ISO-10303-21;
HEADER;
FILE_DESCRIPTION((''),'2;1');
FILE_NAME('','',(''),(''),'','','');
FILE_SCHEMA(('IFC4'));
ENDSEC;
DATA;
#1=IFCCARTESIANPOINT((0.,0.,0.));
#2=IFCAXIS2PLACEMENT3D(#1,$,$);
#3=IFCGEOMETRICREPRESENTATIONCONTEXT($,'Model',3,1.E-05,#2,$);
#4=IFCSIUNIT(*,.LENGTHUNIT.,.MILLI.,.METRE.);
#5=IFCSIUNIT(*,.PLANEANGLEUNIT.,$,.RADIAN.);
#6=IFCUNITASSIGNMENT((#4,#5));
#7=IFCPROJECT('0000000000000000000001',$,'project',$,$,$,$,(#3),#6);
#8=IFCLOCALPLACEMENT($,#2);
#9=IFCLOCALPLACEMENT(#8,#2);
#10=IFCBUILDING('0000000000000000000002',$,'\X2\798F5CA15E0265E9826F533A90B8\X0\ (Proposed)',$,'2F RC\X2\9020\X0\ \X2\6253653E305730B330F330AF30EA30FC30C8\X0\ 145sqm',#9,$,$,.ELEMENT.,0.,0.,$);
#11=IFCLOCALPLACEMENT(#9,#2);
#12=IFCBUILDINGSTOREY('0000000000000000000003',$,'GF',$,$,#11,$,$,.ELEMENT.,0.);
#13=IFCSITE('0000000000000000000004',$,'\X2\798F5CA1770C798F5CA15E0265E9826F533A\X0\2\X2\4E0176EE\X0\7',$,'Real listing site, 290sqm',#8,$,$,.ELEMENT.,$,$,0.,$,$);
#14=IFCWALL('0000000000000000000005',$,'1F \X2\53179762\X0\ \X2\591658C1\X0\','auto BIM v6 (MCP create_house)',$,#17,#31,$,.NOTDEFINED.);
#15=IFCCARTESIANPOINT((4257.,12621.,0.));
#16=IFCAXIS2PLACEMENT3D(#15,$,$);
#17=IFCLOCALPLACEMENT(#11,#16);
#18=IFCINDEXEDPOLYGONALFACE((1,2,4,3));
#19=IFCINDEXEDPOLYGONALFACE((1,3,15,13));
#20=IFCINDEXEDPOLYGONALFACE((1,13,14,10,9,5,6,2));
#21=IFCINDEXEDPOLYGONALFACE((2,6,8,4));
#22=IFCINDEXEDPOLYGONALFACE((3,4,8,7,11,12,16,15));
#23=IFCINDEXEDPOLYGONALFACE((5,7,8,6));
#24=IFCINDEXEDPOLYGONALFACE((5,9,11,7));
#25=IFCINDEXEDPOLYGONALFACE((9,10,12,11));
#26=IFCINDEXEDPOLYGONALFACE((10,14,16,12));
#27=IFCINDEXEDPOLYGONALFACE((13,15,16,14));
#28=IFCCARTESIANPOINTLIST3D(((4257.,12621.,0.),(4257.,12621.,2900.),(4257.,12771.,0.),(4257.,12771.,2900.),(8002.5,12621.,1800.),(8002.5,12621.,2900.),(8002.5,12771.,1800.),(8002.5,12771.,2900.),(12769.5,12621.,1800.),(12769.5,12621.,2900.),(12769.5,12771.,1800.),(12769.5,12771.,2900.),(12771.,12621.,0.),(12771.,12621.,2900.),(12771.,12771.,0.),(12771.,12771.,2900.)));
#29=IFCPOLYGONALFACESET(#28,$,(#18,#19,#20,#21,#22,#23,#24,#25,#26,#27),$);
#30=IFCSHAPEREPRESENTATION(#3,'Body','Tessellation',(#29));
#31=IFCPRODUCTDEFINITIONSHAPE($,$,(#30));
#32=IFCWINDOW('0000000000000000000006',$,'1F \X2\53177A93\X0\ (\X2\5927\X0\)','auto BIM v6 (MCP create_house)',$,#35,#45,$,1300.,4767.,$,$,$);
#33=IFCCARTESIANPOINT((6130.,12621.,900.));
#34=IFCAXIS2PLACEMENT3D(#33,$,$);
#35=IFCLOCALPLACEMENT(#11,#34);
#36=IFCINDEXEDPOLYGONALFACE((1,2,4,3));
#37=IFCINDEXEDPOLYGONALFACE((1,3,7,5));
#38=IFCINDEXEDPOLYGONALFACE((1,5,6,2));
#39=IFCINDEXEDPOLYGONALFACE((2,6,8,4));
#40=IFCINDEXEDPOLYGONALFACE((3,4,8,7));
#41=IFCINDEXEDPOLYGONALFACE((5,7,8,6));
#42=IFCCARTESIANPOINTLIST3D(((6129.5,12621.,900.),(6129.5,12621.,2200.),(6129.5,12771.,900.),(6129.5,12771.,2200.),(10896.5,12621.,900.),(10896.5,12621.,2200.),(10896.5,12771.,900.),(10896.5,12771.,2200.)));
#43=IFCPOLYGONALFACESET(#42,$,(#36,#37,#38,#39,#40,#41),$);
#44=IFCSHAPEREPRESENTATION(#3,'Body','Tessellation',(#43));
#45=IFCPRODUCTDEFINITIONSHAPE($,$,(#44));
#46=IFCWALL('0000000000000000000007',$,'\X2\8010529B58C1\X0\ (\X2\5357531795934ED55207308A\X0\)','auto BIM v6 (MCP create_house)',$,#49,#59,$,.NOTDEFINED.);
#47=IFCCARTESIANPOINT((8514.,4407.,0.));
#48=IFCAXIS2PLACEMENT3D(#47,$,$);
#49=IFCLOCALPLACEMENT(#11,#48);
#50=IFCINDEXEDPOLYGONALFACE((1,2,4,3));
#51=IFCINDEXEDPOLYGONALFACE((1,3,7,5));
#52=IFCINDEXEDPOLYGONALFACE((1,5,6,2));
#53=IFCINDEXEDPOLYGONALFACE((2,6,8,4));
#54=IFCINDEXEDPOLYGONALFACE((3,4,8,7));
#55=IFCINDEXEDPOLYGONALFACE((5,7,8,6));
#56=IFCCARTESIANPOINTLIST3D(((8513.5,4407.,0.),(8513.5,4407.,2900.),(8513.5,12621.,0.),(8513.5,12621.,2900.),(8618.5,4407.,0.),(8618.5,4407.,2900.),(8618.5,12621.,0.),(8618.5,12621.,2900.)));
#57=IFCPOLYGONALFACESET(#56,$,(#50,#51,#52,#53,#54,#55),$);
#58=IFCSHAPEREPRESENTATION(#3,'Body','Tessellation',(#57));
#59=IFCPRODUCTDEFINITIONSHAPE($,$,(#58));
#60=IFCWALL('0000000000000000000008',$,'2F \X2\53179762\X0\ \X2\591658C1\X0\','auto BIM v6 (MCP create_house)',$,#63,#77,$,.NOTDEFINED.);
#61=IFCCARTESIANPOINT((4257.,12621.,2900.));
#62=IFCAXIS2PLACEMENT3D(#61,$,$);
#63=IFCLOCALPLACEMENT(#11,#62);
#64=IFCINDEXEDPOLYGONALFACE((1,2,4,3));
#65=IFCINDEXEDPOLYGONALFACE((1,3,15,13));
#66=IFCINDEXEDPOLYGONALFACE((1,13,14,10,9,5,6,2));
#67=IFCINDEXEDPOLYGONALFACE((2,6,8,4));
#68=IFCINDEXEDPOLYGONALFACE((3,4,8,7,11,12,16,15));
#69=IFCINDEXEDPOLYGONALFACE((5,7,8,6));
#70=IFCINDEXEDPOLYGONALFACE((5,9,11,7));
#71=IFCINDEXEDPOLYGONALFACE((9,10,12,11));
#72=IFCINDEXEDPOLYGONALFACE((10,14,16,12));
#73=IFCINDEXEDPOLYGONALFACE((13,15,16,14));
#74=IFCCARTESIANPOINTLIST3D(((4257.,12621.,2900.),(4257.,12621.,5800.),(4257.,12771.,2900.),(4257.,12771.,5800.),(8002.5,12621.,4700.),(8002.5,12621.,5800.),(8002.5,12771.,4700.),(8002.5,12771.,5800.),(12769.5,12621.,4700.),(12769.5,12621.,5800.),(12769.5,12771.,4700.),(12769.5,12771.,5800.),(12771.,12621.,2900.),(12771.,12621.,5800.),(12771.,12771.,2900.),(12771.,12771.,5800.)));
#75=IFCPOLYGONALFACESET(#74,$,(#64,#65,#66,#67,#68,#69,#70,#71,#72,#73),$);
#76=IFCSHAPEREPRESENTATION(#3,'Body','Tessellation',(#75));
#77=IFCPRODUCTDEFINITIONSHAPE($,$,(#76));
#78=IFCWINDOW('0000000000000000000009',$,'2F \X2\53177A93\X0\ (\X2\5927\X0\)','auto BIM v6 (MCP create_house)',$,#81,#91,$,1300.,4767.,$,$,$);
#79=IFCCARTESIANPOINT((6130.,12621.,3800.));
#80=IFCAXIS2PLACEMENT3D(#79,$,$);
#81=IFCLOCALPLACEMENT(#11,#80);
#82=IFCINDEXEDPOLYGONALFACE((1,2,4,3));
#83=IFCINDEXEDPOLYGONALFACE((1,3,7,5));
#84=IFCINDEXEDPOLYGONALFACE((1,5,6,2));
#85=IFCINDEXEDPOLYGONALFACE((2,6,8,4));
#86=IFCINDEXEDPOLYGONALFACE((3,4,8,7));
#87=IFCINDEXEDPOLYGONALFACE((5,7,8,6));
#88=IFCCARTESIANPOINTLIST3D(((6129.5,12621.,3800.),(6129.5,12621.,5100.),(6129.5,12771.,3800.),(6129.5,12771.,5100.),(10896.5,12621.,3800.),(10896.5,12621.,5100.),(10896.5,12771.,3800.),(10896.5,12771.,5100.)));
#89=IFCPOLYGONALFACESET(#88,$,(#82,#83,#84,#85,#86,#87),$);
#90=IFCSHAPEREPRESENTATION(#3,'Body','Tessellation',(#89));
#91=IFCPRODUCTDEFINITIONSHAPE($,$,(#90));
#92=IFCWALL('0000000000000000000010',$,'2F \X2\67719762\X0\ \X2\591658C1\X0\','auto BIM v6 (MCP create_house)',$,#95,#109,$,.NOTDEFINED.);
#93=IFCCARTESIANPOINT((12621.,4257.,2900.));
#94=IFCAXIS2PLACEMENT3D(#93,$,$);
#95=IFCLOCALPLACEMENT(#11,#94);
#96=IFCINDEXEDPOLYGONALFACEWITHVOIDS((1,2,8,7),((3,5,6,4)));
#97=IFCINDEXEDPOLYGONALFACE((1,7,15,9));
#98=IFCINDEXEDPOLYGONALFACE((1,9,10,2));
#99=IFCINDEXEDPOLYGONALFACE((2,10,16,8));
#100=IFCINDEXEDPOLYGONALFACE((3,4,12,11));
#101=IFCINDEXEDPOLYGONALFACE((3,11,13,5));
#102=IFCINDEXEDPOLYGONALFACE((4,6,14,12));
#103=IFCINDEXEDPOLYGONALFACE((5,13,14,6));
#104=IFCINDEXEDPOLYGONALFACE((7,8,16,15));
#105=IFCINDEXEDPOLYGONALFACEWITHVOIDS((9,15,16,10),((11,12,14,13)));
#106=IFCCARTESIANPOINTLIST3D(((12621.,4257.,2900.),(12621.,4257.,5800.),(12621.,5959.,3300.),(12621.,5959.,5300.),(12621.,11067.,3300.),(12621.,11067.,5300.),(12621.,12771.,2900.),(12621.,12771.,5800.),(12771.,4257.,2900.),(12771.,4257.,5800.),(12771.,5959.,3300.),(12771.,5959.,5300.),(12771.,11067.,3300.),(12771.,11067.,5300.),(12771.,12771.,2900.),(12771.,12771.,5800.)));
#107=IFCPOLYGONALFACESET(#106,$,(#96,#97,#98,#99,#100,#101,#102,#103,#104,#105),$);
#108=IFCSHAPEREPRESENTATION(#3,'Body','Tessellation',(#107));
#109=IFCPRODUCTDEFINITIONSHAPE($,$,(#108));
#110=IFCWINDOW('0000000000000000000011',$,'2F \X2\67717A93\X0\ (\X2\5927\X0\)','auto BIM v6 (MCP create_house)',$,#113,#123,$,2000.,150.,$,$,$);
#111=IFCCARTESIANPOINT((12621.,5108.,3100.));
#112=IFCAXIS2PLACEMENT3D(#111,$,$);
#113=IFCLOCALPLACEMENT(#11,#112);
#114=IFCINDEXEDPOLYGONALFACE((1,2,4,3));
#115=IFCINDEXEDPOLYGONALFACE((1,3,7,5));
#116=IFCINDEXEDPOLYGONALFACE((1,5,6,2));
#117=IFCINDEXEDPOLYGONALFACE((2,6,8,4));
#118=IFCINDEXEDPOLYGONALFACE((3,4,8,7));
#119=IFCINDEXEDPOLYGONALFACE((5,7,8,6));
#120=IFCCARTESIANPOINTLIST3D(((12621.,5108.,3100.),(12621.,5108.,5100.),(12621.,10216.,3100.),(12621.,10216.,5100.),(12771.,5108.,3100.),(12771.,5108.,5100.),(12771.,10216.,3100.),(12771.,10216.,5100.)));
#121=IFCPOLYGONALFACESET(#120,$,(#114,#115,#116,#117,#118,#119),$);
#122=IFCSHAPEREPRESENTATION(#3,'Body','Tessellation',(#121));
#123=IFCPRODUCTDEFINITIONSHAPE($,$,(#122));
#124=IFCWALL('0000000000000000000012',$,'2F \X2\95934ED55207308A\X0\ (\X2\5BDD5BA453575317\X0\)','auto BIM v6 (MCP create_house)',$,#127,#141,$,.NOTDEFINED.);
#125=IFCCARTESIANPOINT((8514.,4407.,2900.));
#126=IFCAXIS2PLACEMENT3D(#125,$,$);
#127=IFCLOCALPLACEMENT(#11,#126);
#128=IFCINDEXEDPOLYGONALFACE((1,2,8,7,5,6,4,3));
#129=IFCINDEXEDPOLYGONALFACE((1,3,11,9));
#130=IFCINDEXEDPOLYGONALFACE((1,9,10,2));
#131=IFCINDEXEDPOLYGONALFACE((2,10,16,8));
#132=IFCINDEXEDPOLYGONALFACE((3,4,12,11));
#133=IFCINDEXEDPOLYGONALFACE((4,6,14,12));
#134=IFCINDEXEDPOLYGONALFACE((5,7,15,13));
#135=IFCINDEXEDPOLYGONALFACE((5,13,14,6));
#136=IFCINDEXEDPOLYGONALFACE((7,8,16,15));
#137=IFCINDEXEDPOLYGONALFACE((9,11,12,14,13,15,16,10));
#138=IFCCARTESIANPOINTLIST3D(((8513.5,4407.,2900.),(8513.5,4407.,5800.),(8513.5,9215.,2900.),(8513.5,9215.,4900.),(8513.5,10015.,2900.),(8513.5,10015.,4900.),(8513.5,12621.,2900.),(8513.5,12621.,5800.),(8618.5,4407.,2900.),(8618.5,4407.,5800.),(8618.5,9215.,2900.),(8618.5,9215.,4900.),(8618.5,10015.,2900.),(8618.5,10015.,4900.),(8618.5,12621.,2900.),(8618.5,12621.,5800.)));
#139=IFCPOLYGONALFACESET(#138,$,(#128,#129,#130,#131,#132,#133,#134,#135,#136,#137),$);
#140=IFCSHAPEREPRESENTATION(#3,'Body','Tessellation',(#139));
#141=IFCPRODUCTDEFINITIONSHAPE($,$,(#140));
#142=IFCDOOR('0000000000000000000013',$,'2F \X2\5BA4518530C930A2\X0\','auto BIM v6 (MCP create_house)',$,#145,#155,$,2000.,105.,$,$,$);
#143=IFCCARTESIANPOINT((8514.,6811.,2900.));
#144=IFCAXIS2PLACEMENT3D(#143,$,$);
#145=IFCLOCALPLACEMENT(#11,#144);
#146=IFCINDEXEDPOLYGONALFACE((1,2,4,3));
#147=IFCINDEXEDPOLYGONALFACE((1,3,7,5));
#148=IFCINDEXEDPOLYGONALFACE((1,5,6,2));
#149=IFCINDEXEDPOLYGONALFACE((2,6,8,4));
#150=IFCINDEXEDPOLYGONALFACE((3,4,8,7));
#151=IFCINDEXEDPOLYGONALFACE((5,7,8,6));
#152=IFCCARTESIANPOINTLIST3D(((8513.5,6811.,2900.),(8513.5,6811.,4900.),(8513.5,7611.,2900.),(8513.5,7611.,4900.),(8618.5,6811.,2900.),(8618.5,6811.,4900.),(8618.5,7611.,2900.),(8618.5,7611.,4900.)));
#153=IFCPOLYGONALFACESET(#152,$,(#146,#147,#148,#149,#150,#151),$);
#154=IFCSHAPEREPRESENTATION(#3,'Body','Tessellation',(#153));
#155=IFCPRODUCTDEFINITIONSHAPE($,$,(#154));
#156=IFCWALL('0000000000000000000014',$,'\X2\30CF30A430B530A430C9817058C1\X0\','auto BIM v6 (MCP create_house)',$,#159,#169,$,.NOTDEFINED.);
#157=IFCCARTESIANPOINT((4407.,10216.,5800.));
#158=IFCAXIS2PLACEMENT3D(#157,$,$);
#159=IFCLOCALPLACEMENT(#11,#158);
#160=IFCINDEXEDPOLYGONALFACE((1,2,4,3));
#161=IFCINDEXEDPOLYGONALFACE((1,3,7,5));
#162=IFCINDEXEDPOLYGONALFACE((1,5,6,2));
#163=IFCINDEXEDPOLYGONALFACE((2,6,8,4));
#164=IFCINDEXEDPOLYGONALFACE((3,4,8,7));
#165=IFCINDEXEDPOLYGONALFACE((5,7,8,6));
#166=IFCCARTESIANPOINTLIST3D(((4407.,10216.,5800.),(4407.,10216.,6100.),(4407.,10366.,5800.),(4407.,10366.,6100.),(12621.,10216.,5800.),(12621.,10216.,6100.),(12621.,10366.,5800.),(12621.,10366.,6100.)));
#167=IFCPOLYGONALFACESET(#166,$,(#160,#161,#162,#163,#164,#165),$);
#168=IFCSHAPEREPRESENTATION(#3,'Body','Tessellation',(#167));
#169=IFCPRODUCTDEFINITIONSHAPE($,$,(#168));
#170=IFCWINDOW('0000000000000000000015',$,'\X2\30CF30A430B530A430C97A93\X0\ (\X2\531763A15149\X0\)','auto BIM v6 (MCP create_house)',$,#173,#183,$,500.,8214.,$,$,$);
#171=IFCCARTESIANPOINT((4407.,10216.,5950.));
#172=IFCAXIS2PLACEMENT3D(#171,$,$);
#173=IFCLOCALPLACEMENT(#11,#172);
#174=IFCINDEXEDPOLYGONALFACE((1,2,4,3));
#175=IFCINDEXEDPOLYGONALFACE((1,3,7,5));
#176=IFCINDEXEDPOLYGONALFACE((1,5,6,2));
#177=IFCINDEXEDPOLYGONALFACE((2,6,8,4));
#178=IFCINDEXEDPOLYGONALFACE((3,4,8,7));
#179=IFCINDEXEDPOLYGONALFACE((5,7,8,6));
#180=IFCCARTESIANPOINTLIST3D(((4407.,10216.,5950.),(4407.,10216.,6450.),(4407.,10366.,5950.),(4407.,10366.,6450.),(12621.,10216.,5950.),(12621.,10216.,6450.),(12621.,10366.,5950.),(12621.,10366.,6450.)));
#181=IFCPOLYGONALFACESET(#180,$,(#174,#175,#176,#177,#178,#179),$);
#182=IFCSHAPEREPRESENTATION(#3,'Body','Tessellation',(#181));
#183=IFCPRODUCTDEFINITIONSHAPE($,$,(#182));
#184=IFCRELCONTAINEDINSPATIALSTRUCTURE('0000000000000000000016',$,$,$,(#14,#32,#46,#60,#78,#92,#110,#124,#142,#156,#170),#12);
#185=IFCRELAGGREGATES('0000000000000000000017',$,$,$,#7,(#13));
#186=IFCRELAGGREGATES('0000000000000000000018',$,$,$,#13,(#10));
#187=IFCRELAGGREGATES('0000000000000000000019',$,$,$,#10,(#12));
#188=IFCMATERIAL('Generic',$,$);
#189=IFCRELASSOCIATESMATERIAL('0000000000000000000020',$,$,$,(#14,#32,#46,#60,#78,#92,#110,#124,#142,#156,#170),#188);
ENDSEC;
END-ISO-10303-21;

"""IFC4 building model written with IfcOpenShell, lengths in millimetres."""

from ifc_helpers import new_model, si_unit, frame, frame_2d, origin, place, context, project, spatial, rectangle, extrude, material, element, fill, save


model = new_model("IFC4")

# Units and contexts
model_context = context("Model", 3, precision=1e-05, world=origin())
ifc_project = project(units=[si_unit("LENGTHUNIT", "METRE", prefix="MILLI"), si_unit("PLANEANGLEUNIT", "RADIAN")], contexts=[model_context])

# Site, building, storey
site_placement = place(None, origin())
site = spatial("IfcSite", under=ifc_project, at=site_placement, Name="福岡県福岡市早良区2丁目7", ObjectType="Real listing site, 290sqm", CompositionType="ELEMENT", RefElevation=0.0)
building_placement = place(site_placement, origin())
building = spatial("IfcBuilding", under=site, at=building_placement, Name="福岡市早良区邸 (Proposed)", ObjectType="2F RC造 打放しコンクリート 145sqm", CompositionType="ELEMENT", ElevationOfRefHeight=0.0, ElevationOfTerrain=0.0)
storey_placement = place(building_placement, origin())
storey = spatial("IfcBuildingStorey", under=building, at=storey_placement, Name="GF", CompositionType="ELEMENT", Elevation=0.0)

# Wall, opening, window
ifc_material = material(Name="Generic")
wall_1_placement = place(storey_placement, frame((4257.0, 12621.0, 0.0)))
wall_1 = element("IfcWall", 1, at=wall_1_placement, inside=storey, material=ifc_material, Name="1F 北面 外壁", Description="auto BIM v6 (MCP create_house)", PredefinedType="NOTDEFINED", context=model_context, shape_type="SweptSolid", body=[
    extrude(rectangle(XDim=8514.0, YDim=150.0, at=frame_2d((4257.0, 75.0))), frame((4257.0, 12621.0, 0.0)), (0.0, 0.0, 1.0), 2900.0),
])
opening_1_placement = place(storey_placement, frame((6130.0, 12621.0, 900.0)))
opening_1 = element("IfcOpeningElement", 2, at=opening_1_placement, cuts=wall_1, PredefinedType="NOTDEFINED", context=model_context, shape_type="SweptSolid", body=[
    extrude(rectangle(XDim=4767.0, YDim=150.0, at=frame_2d((2383.0, 75.0))), frame((6130.0, 12621.0, 900.0)), (0.0, 0.0, 1.0), 1300.0),
])
window_1_placement = place(storey_placement, frame((6130.0, 12621.0, 900.0)))
window_1 = element("IfcWindow", 3, at=window_1_placement, inside=storey, material=ifc_material, Name="1F 北窓 (大)", Description="auto BIM v6 (MCP create_house)", OverallHeight=1300.0, OverallWidth=4767.0, context=model_context, shape_type="SweptSolid", body=[
    extrude(rectangle(XDim=4767.0, YDim=150.0, at=frame_2d((2383.0, 75.0))), frame((6130.0, 12621.0, 900.0)), (0.0, 0.0, 1.0), 1300.0),
])
fill(opening_1, window_1)

# Wall
wall_2_placement = place(storey_placement, frame((8514.0, 4407.0, 0.0)))
element("IfcWall", 4, at=wall_2_placement, inside=storey, material=ifc_material, Name="耐力壁 (南北間仕切り)", Description="auto BIM v6 (MCP create_house)", PredefinedType="NOTDEFINED", context=model_context, shape_type="SweptSolid", body=[
    extrude(rectangle(XDim=105.0, YDim=8214.0, at=frame_2d((52.0, 4107.0))), frame((8514.0, 4407.0, 0.0)), (0.0, 0.0, 1.0), 2900.0),
])

# Walls, openings, windows
wall_3_placement = place(storey_placement, frame((4257.0, 12621.0, 2900.0)))
wall_3 = element("IfcWall", 5, at=wall_3_placement, inside=storey, material=ifc_material, Name="2F 北面 外壁", Description="auto BIM v6 (MCP create_house)", PredefinedType="NOTDEFINED", context=model_context, shape_type="SweptSolid", body=[
    extrude(rectangle(XDim=8514.0, YDim=150.0, at=frame_2d((4257.0, 75.0))), frame((4257.0, 12621.0, 2900.0)), (0.0, 0.0, 1.0), 2900.0),
])
opening_2_placement = place(storey_placement, frame((6130.0, 12621.0, 3800.0)))
opening_2 = element("IfcOpeningElement", 6, at=opening_2_placement, cuts=wall_3, PredefinedType="NOTDEFINED", context=model_context, shape_type="SweptSolid", body=[
    extrude(rectangle(XDim=4767.0, YDim=150.0, at=frame_2d((2383.0, 75.0))), frame((6130.0, 12621.0, 3800.0)), (0.0, 0.0, 1.0), 1300.0),
])
window_2_placement = place(storey_placement, frame((6130.0, 12621.0, 3800.0)))
window_2 = element("IfcWindow", 7, at=window_2_placement, inside=storey, material=ifc_material, Name="2F 北窓 (大)", Description="auto BIM v6 (MCP create_house)", OverallHeight=1300.0, OverallWidth=4767.0, context=model_context, shape_type="SweptSolid", body=[
    extrude(rectangle(XDim=4767.0, YDim=150.0, at=frame_2d((2383.0, 75.0))), frame((6130.0, 12621.0, 3800.0)), (0.0, 0.0, 1.0), 1300.0),
])
fill(opening_2, window_2)
wall_4_placement = place(storey_placement, frame((12621.0, 4257.0, 2900.0)))
wall_4 = element("IfcWall", 8, at=wall_4_placement, inside=storey, material=ifc_material, Name="2F 東面 外壁", Description="auto BIM v6 (MCP create_house)", PredefinedType="NOTDEFINED", context=model_context, shape_type="SweptSolid", body=[
    extrude(rectangle(XDim=150.0, YDim=8514.0, at=frame_2d((75.0, 4257.0))), frame((12621.0, 4257.0, 2900.0)), (0.0, 0.0, 1.0), 2900.0),
])
opening_3_placement = place(storey_placement, frame((12621.0, 5108.0, 3100.0)))
opening_3 = element("IfcOpeningElement", 9, at=opening_3_placement, cuts=wall_4, PredefinedType="NOTDEFINED", context=model_context, shape_type="SweptSolid", body=[
    extrude(rectangle(XDim=150.0, YDim=5108.0, at=frame_2d((75.0, 2554.0))), frame((12621.0, 5108.0, 3100.0)), (0.0, 0.0, 1.0), 2000.0),
])
window_3_placement = place(storey_placement, frame((12621.0, 5108.0, 3100.0)))
window_3 = element("IfcWindow", 10, at=window_3_placement, inside=storey, material=ifc_material, Name="2F 東窓 (大)", Description="auto BIM v6 (MCP create_house)", OverallHeight=2000.0, OverallWidth=150.0, context=model_context, shape_type="SweptSolid", body=[
    extrude(rectangle(XDim=150.0, YDim=5108.0, at=frame_2d((75.0, 2554.0))), frame((12621.0, 5108.0, 3100.0)), (0.0, 0.0, 1.0), 2000.0),
])
fill(opening_3, window_3)

# Wall, opening, door
wall_5_placement = place(storey_placement, frame((8514.0, 4407.0, 2900.0)))
wall_5 = element("IfcWall", 11, at=wall_5_placement, inside=storey, material=ifc_material, Name="2F 間仕切り (寝室南北)", Description="auto BIM v6 (MCP create_house)", PredefinedType="NOTDEFINED", context=model_context, shape_type="SweptSolid", body=[
    extrude(rectangle(XDim=105.0, YDim=8214.0, at=frame_2d((52.0, 4107.0))), frame((8514.0, 4407.0, 2900.0)), (0.0, 0.0, 1.0), 2900.0),
])
opening_4_placement = place(storey_placement, frame((8514.0, 6811.0, 2900.0)))
opening_4 = element("IfcOpeningElement", 12, at=opening_4_placement, cuts=wall_5, PredefinedType="NOTDEFINED", context=model_context, shape_type="SweptSolid", body=[
    extrude(rectangle(XDim=105.0, YDim=800.0, at=frame_2d((52.0, 400.0))), frame((8514.0, 6811.0, 2900.0)), (0.0, 0.0, 1.0), 2000.0),
])
door_placement = place(storey_placement, frame((8514.0, 6811.0, 2900.0)))
door = element("IfcDoor", 13, at=door_placement, inside=storey, material=ifc_material, Name="2F 室内ドア", Description="auto BIM v6 (MCP create_house)", OverallHeight=2000.0, OverallWidth=105.0, context=model_context, shape_type="SweptSolid", body=[
    extrude(rectangle(XDim=105.0, YDim=800.0, at=frame_2d((52.0, 400.0))), frame((8514.0, 6811.0, 2900.0)), (0.0, 0.0, 1.0), 2000.0),
])
fill(opening_4, door)

# Wall, opening, window
wall_6_placement = place(storey_placement, frame((4407.0, 10216.0, 5800.0)))
wall_6 = element("IfcWall", 14, at=wall_6_placement, inside=storey, material=ifc_material, Name="ハイサイド腰壁", Description="auto BIM v6 (MCP create_house)", PredefinedType="NOTDEFINED", context=model_context, shape_type="SweptSolid", body=[
    extrude(rectangle(XDim=8214.0, YDim=150.0, at=frame_2d((4107.0, 75.0))), frame((4407.0, 10216.0, 5800.0)), (0.0, 0.0, 1.0), 700.0),
])
opening_5_placement = place(storey_placement, frame((4407.0, 10216.0, 5950.0)))
opening_5 = element("IfcOpeningElement", 15, at=opening_5_placement, cuts=wall_6, PredefinedType="NOTDEFINED", context=model_context, shape_type="SweptSolid", body=[
    extrude(rectangle(XDim=8214.0, YDim=150.0, at=frame_2d((4107.0, 75.0))), frame((4407.0, 10216.0, 5950.0)), (0.0, 0.0, 1.0), 500.0),
])
window_4_placement = place(storey_placement, frame((4407.0, 10216.0, 5950.0)))
window_4 = element("IfcWindow", 16, at=window_4_placement, inside=storey, material=ifc_material, Name="ハイサイド窓 (北採光)", Description="auto BIM v6 (MCP create_house)", OverallHeight=500.0, OverallWidth=8214.0, context=model_context, shape_type="SweptSolid", body=[
    extrude(rectangle(XDim=8214.0, YDim=150.0, at=frame_2d((4107.0, 75.0))), frame((4407.0, 10216.0, 5950.0)), (0.0, 0.0, 1.0), 500.0),
])
fill(opening_5, window_4)

save(model, "model.ifc")
